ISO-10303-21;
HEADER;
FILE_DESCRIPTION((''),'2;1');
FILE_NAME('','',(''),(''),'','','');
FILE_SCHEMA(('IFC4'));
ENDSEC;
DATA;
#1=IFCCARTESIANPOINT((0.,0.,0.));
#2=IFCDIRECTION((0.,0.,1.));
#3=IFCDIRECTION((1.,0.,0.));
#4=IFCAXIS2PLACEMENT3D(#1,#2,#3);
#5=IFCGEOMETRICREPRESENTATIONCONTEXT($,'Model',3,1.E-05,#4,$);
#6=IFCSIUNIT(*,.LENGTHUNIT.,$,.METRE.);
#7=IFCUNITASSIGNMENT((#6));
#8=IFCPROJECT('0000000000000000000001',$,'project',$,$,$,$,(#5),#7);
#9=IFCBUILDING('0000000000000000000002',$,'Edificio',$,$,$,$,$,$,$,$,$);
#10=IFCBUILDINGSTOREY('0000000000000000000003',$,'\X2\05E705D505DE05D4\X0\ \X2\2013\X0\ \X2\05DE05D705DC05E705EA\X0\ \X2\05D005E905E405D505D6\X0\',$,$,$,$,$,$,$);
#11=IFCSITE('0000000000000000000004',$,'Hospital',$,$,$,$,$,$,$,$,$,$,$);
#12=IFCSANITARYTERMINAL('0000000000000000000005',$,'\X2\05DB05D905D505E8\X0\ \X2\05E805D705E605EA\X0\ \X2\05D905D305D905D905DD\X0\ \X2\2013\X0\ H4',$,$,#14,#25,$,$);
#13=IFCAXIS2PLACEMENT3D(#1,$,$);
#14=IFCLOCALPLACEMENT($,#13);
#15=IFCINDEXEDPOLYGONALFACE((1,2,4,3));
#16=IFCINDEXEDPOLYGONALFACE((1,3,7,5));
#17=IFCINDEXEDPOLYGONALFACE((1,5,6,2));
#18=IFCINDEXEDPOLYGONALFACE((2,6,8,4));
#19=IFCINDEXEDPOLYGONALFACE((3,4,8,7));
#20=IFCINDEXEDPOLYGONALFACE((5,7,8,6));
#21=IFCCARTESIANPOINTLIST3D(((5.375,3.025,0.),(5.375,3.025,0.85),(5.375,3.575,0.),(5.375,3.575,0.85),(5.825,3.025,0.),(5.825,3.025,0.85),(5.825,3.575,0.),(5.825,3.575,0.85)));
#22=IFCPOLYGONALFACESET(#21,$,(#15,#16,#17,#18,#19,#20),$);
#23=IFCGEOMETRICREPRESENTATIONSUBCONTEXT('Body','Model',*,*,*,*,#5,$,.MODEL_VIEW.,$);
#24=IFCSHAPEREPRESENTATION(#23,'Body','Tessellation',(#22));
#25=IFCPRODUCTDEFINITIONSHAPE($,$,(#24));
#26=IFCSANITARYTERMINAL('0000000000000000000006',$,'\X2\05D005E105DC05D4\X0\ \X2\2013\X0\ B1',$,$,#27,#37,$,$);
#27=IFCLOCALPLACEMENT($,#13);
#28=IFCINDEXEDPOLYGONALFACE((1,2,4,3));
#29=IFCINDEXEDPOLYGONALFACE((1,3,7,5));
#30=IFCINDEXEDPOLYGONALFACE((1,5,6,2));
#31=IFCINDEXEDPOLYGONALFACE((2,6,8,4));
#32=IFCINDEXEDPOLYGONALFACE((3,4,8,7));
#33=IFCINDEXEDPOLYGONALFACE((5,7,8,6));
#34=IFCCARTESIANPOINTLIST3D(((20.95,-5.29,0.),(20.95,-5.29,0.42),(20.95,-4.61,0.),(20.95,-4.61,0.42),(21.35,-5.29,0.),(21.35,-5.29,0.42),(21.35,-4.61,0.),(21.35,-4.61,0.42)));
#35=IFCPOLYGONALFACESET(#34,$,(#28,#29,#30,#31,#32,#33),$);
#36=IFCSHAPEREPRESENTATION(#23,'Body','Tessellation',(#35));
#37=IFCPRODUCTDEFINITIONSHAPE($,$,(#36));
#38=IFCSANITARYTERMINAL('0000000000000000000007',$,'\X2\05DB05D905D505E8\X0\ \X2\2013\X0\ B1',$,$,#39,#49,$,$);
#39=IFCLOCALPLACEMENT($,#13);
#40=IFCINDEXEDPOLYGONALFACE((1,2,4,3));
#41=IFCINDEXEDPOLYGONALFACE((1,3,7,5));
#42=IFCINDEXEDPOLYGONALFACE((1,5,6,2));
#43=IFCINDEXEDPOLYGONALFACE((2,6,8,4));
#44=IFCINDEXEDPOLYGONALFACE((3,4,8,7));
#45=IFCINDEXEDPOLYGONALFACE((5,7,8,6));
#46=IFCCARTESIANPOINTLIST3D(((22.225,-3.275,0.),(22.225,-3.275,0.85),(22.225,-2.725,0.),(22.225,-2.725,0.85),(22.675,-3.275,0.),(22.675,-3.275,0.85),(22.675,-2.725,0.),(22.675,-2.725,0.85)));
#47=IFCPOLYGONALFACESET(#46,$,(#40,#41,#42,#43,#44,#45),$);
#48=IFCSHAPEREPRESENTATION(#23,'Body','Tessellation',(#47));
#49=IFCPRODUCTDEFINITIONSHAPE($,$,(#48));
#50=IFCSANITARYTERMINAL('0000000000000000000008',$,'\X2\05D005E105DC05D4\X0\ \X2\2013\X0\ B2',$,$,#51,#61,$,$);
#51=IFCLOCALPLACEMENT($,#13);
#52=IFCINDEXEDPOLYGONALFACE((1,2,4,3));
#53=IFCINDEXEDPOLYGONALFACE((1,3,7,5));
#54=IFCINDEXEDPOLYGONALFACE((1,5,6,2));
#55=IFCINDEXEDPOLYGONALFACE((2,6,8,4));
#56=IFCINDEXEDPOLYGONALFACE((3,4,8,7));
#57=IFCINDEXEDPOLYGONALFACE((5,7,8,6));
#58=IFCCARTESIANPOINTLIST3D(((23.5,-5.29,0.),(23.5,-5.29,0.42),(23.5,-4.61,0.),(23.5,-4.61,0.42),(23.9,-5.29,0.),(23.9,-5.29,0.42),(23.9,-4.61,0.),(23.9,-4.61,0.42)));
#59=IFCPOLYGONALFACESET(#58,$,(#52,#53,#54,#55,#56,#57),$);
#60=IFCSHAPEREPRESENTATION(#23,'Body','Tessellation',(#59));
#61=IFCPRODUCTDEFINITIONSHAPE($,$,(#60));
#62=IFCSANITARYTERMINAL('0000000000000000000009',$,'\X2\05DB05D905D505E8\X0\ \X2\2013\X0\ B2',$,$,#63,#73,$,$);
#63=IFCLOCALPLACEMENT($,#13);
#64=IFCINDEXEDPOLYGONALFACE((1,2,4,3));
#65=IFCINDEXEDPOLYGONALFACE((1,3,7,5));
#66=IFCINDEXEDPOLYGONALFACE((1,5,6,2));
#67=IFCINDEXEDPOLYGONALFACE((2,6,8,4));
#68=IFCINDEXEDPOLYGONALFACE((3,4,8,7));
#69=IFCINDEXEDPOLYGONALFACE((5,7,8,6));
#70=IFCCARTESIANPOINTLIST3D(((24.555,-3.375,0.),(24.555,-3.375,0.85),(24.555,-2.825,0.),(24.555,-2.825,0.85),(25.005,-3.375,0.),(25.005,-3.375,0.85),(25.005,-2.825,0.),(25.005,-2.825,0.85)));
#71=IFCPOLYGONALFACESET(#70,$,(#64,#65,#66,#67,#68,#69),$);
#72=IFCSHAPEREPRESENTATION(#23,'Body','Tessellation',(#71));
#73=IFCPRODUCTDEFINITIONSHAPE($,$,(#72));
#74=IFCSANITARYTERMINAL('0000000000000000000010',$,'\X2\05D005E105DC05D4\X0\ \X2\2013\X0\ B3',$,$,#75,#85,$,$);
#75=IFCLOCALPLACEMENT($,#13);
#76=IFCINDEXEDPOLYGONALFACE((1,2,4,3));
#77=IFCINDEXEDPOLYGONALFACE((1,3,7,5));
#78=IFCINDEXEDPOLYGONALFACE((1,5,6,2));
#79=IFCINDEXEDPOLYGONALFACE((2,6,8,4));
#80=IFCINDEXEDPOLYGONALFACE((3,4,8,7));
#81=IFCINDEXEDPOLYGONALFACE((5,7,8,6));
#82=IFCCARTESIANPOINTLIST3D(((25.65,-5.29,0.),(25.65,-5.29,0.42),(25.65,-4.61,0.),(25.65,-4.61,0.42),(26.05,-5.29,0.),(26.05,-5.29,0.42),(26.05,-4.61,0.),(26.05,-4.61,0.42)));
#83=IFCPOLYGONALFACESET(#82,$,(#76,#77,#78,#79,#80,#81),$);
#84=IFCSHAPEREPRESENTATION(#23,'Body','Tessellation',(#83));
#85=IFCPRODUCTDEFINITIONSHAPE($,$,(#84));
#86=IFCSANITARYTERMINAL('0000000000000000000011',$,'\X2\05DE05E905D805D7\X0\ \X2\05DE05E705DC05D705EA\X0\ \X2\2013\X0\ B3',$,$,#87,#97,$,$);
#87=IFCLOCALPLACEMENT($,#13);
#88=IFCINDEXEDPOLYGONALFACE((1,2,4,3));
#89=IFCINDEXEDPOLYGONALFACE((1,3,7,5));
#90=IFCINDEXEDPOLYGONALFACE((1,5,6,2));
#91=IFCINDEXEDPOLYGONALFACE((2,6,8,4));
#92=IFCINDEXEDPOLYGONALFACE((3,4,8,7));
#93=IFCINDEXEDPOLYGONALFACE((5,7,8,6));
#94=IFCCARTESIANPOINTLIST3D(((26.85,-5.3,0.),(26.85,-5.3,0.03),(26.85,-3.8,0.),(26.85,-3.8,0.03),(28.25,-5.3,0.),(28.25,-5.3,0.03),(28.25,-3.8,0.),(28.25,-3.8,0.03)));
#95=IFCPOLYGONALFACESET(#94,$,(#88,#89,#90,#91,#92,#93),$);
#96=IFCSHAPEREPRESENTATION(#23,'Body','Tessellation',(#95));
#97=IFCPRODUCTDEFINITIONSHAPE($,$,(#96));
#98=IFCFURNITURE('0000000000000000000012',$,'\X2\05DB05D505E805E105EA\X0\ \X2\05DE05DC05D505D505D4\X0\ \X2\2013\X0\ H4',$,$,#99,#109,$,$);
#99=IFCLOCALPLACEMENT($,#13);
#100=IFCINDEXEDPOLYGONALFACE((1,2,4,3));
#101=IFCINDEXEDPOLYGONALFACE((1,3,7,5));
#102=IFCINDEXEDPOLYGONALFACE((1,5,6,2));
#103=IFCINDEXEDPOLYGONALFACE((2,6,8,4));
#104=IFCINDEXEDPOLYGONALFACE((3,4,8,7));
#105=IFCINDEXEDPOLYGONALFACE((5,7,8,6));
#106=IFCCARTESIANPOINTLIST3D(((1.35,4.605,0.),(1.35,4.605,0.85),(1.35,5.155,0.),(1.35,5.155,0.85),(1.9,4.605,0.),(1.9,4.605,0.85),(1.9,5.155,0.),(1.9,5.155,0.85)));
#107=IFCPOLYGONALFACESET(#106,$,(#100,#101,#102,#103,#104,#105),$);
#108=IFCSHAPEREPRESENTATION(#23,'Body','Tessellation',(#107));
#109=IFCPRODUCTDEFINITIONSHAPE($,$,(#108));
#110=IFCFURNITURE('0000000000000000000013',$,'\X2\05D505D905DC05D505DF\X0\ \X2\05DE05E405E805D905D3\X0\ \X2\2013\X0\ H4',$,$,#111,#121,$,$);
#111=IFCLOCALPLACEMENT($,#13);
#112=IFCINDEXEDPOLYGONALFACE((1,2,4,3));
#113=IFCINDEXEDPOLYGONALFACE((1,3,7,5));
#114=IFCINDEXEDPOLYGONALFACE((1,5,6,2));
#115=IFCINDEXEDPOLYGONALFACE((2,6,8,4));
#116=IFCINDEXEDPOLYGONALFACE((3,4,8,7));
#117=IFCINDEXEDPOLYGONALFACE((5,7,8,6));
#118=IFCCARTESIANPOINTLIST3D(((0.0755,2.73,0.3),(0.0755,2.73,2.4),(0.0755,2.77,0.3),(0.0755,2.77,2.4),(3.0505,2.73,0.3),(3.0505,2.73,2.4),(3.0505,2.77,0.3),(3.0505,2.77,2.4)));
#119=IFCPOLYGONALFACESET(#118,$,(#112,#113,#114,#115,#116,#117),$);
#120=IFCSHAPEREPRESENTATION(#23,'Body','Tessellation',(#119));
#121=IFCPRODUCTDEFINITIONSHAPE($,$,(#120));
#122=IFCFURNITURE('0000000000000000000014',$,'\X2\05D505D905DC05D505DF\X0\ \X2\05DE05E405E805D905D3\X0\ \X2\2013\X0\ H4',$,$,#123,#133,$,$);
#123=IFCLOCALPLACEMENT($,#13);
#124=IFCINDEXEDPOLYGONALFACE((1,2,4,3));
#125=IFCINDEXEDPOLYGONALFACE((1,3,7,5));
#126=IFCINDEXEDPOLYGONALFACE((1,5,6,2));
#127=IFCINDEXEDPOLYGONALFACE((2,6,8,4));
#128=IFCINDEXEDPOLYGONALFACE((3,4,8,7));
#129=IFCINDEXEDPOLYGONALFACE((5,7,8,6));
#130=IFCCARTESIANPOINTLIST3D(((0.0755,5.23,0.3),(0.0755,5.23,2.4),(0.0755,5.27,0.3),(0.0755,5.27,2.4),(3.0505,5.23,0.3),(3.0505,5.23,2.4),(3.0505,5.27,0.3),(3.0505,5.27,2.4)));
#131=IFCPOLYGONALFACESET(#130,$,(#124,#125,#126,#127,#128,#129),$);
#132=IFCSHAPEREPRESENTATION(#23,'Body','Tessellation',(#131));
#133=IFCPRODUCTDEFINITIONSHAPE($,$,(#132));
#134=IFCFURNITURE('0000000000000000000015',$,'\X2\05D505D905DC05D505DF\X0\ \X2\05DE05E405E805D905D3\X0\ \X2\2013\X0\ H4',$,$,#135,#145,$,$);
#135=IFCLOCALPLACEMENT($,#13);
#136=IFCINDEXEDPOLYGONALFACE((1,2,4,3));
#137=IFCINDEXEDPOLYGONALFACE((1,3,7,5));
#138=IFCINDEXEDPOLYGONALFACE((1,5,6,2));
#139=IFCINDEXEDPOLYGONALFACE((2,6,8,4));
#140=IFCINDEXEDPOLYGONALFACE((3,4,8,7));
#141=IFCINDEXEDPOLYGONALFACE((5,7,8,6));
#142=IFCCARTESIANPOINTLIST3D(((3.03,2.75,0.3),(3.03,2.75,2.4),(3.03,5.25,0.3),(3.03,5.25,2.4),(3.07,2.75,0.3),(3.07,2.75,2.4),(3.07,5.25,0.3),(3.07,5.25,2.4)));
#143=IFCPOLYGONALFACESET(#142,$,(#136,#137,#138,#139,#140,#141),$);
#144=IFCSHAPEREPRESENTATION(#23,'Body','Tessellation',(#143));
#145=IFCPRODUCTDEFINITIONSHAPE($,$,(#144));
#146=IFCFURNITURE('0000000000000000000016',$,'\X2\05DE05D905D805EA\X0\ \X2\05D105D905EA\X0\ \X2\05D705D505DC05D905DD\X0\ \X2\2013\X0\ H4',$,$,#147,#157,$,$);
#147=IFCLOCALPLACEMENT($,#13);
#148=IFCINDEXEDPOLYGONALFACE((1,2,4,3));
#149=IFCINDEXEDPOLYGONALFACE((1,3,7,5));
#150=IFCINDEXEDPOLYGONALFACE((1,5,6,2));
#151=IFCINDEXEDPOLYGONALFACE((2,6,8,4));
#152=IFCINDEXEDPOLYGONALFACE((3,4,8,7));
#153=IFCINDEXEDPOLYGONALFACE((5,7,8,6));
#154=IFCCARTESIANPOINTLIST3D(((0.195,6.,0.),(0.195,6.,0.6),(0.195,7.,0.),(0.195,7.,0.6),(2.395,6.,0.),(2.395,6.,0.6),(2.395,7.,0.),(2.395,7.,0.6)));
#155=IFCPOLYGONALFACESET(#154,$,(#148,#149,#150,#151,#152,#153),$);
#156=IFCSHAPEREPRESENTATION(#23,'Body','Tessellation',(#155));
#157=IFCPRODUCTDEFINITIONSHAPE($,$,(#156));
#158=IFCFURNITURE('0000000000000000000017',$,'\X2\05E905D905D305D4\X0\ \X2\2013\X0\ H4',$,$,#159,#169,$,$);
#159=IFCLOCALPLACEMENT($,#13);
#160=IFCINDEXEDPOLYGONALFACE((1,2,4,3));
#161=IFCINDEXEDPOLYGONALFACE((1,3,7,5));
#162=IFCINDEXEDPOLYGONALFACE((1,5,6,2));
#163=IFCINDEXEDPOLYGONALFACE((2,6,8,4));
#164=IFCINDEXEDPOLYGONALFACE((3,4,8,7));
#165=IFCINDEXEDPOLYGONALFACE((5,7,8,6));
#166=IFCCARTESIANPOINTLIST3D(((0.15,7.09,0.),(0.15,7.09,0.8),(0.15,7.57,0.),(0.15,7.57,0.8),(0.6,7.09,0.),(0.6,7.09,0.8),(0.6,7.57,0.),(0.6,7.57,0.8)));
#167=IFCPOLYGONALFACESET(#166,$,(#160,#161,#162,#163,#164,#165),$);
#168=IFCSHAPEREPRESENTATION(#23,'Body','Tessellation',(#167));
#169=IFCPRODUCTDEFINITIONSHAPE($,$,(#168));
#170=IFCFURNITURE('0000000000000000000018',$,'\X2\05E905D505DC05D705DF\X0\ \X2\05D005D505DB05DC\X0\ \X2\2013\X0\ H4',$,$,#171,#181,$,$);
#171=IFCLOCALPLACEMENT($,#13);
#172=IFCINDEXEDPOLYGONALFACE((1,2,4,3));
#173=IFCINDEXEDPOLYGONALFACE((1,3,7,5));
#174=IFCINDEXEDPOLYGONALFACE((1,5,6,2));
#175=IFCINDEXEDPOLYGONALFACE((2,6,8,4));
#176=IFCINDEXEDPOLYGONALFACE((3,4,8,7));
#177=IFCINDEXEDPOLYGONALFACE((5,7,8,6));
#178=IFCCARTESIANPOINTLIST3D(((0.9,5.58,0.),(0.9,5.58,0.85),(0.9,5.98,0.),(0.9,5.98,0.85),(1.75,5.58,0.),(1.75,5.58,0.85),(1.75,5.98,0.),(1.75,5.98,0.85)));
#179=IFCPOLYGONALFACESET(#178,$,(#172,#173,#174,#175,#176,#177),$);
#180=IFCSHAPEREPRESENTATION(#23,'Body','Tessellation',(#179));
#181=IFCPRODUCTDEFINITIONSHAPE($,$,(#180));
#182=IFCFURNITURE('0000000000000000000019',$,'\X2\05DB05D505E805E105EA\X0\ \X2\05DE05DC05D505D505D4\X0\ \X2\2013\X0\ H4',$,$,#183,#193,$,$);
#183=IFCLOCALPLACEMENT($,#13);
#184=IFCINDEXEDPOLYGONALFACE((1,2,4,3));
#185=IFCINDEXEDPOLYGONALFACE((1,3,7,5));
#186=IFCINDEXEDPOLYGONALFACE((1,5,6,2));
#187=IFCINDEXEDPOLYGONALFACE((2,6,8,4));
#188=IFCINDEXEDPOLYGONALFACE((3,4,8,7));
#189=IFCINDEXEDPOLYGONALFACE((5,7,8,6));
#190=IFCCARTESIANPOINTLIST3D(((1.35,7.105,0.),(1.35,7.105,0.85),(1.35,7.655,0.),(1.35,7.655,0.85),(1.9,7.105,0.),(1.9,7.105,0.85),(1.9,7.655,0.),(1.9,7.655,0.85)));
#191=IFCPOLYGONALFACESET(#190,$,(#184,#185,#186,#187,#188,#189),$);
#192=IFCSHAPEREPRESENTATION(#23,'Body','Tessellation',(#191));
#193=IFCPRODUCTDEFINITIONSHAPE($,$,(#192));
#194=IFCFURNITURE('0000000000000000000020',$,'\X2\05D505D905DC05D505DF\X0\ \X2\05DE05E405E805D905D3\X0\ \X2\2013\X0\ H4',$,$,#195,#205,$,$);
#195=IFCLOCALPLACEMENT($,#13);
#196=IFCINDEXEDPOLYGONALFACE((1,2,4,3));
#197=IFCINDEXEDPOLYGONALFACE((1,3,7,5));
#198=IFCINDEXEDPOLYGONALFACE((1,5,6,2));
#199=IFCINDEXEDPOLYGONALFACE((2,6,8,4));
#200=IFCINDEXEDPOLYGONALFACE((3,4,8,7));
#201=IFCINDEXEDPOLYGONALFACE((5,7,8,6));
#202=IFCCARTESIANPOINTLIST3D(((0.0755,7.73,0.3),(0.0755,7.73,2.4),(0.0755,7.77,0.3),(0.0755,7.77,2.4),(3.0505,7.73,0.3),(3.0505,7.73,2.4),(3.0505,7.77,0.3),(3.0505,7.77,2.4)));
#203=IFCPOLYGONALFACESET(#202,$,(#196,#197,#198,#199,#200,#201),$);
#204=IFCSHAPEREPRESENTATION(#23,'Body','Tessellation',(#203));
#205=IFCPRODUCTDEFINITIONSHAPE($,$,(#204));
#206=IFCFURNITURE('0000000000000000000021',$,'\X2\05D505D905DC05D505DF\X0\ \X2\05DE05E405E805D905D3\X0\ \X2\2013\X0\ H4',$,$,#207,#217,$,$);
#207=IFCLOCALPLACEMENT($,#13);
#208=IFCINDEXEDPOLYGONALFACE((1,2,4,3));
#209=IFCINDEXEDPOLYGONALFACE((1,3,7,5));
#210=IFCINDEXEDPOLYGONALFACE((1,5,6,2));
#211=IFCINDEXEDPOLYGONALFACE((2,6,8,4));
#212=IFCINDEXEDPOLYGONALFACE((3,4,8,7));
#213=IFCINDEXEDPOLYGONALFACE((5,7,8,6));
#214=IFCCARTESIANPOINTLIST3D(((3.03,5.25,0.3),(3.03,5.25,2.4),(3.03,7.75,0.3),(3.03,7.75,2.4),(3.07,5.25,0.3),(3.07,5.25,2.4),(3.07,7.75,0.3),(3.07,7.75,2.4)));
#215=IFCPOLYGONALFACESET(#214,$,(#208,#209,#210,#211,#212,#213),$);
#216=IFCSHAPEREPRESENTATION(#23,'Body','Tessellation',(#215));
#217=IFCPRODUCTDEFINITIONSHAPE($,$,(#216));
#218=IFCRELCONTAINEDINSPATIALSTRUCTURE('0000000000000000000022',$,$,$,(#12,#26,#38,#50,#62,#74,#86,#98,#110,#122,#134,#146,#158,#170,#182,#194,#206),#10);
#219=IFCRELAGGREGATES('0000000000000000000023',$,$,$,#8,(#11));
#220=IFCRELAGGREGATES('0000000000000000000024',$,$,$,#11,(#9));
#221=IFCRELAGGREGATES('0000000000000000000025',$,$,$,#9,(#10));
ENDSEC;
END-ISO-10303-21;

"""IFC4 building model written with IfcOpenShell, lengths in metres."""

from ifc_helpers import new_model, si_unit, frame, origin_with_axes, context, subcontext, project, spatial, line, indexed_curve, outline, extrude, element, save


model = new_model("IFC4")

# Units and contexts
model_context = context("Model", 3, precision=1e-05, world=origin_with_axes())
body_context = subcontext(model_context, "Body", "Model", "MODEL_VIEW")
ifc_project = project(units=[si_unit("LENGTHUNIT", "METRE")], contexts=[model_context])

# Site, building, storey
site = spatial("IfcSite", under=ifc_project, Name="Hospital")
building = spatial("IfcBuilding", under=site, Name="Edificio")
storey = spatial("IfcBuildingStorey", under=building, Name="קומה – מחלקת אשפוז")

# Sanitary terminals
element("IfcSanitaryTerminal", 1, inside=storey, Name="כיור רחצת ידיים – H4", context=body_context, shape_type="SweptSolid", body=[
    extrude(outline(indexed_curve([(0.0, 0.0), (0.45, 0.0), (0.45, 0.55), (0.0, 0.55)], segments=[line(1, 2, 3, 4, 1)])), frame((5.375, 3.025, 0.0), z_axis=(0.0, 0.0, 1.0), x_axis=(1.0, 0.0, 0.0)), (0.0, 0.0, 1.0), 0.85),
])
element("IfcSanitaryTerminal", 2, inside=storey, Name="אסלה – B1", context=body_context, shape_type="SweptSolid", body=[
    extrude(outline(indexed_curve([(0.0, 0.0), (0.4, 0.0), (0.4, 0.68), (0.0, 0.68)], segments=[line(1, 2, 3, 4, 1)])), frame((20.95, -5.29, 0.0), z_axis=(0.0, 0.0, 1.0), x_axis=(1.0, 0.0, 0.0)), (0.0, 0.0, 1.0), 0.42),
])
element("IfcSanitaryTerminal", 3, inside=storey, Name="כיור – B1", context=body_context, shape_type="SweptSolid", body=[
    extrude(outline(indexed_curve([(0.0, 0.0), (0.45, 0.0), (0.45, 0.55), (0.0, 0.55)], segments=[line(1, 2, 3, 4, 1)])), frame((22.225, -3.275, 0.0), z_axis=(0.0, 0.0, 1.0), x_axis=(1.0, 0.0, 0.0)), (0.0, 0.0, 1.0), 0.85),
])
element("IfcSanitaryTerminal", 4, inside=storey, Name="אסלה – B2", context=body_context, shape_type="SweptSolid", body=[
    extrude(outline(indexed_curve([(0.0, 0.0), (0.4, 0.0), (0.4, 0.68), (0.0, 0.68)], segments=[line(1, 2, 3, 4, 1)])), frame((23.5, -5.29, 0.0), z_axis=(0.0, 0.0, 1.0), x_axis=(1.0, 0.0, 0.0)), (0.0, 0.0, 1.0), 0.42),
])
element("IfcSanitaryTerminal", 5, inside=storey, Name="כיור – B2", context=body_context, shape_type="SweptSolid", body=[
    extrude(outline(indexed_curve([(0.0, 0.0), (0.45, 0.0), (0.45, 0.55), (0.0, 0.55)], segments=[line(1, 2, 3, 4, 1)])), frame((24.555, -3.375, 0.0), z_axis=(0.0, 0.0, 1.0), x_axis=(1.0, 0.0, 0.0)), (0.0, 0.0, 1.0), 0.85),
])
element("IfcSanitaryTerminal", 6, inside=storey, Name="אסלה – B3", context=body_context, shape_type="SweptSolid", body=[
    extrude(outline(indexed_curve([(0.0, 0.0), (0.4, 0.0), (0.4, 0.68), (0.0, 0.68)], segments=[line(1, 2, 3, 4, 1)])), frame((25.65, -5.29, 0.0), z_axis=(0.0, 0.0, 1.0), x_axis=(1.0, 0.0, 0.0)), (0.0, 0.0, 1.0), 0.42),
])
element("IfcSanitaryTerminal", 7, inside=storey, Name="משטח מקלחת – B3", context=body_context, shape_type="SweptSolid", body=[
    extrude(outline(indexed_curve([(0.0, 0.0), (1.4, 0.0), (1.4, 1.5), (0.0, 1.5)], segments=[line(1, 2, 3, 4, 1)])), frame((26.85, -5.3, 0.0), z_axis=(0.0, 0.0, 1.0), x_axis=(1.0, 0.0, 0.0)), (0.0, 0.0, 1.0), 0.03),
])

# Furniture
element("IfcFurniture", 8, inside=storey, Name="כורסת מלווה – H4", context=body_context, shape_type="SweptSolid", body=[
    extrude(outline(indexed_curve([(0.0, 0.0), (0.55, 0.0), (0.55, 0.55), (0.0, 0.55)], segments=[line(1, 2, 3, 4, 1)])), frame((1.35, 4.605, 0.0), z_axis=(0.0, 0.0, 1.0), x_axis=(1.0, 0.0, 0.0)), (0.0, 0.0, 1.0), 0.85),
])
element("IfcFurniture", 9, inside=storey, Name="וילון מפריד – H4", context=body_context, shape_type="SweptSolid", body=[
    extrude(outline(indexed_curve([(0.0, 0.0), (2.975, 0.0), (2.975, 0.04), (0.0, 0.04)], segments=[line(1, 2, 3, 4, 1)])), frame((0.0755, 2.73, 0.3), z_axis=(0.0, 0.0, 1.0), x_axis=(1.0, 0.0, 0.0)), (0.0, 0.0, 1.0), 2.1),
])
element("IfcFurniture", 10, inside=storey, Name="וילון מפריד – H4", context=body_context, shape_type="SweptSolid", body=[
    extrude(outline(indexed_curve([(0.0, 0.0), (2.975, 0.0), (2.975, 0.04), (0.0, 0.04)], segments=[line(1, 2, 3, 4, 1)])), frame((0.0755, 5.23, 0.3), z_axis=(0.0, 0.0, 1.0), x_axis=(1.0, 0.0, 0.0)), (0.0, 0.0, 1.0), 2.1),
])
element("IfcFurniture", 11, inside=storey, Name="וילון מפריד – H4", context=body_context, shape_type="SweptSolid", body=[
    extrude(outline(indexed_curve([(0.0, 0.0), (0.04, 0.0), (0.04, 2.5), (0.0, 2.5)], segments=[line(1, 2, 3, 4, 1)])), frame((3.03, 2.75, 0.3), z_axis=(0.0, 0.0, 1.0), x_axis=(1.0, 0.0, 0.0)), (0.0, 0.0, 1.0), 2.1),
])
element("IfcFurniture", 12, inside=storey, Name="מיטת בית חולים – H4", context=body_context, shape_type="SweptSolid", body=[
    extrude(outline(indexed_curve([(0.0, 0.0), (2.2, 0.0), (2.2, 1.0), (0.0, 1.0)], segments=[line(1, 2, 3, 4, 1)])), frame((0.195, 6.0, 0.0), z_axis=(0.0, 0.0, 1.0), x_axis=(1.0, 0.0, 0.0)), (0.0, 0.0, 1.0), 0.6),
])
element("IfcFurniture", 13, inside=storey, Name="שידה – H4", context=body_context, shape_type="SweptSolid", body=[
    extrude(outline(indexed_curve([(0.0, 0.0), (0.45, 0.0), (0.45, 0.48), (0.0, 0.48)], segments=[line(1, 2, 3, 4, 1)])), frame((0.15, 7.09, 0.0), z_axis=(0.0, 0.0, 1.0), x_axis=(1.0, 0.0, 0.0)), (0.0, 0.0, 1.0), 0.8),
])
element("IfcFurniture", 14, inside=storey, Name="שולחן אוכל – H4", context=body_context, shape_type="SweptSolid", body=[
    extrude(outline(indexed_curve([(0.0, 0.0), (0.85, 0.0), (0.85, 0.4), (0.0, 0.4)], segments=[line(1, 2, 3, 4, 1)])), frame((0.9, 5.58, 0.0), z_axis=(0.0, 0.0, 1.0), x_axis=(1.0, 0.0, 0.0)), (0.0, 0.0, 1.0), 0.85),
])
element("IfcFurniture", 15, inside=storey, Name="כורסת מלווה – H4", context=body_context, shape_type="SweptSolid", body=[
    extrude(outline(indexed_curve([(0.0, 0.0), (0.55, 0.0), (0.55, 0.55), (0.0, 0.55)], segments=[line(1, 2, 3, 4, 1)])), frame((1.35, 7.105, 0.0), z_axis=(0.0, 0.0, 1.0), x_axis=(1.0, 0.0, 0.0)), (0.0, 0.0, 1.0), 0.85),
])
element("IfcFurniture", 16, inside=storey, Name="וילון מפריד – H4", context=body_context, shape_type="SweptSolid", body=[
    extrude(outline(indexed_curve([(0.0, 0.0), (2.975, 0.0), (2.975, 0.04), (0.0, 0.04)], segments=[line(1, 2, 3, 4, 1)])), frame((0.0755, 7.73, 0.3), z_axis=(0.0, 0.0, 1.0), x_axis=(1.0, 0.0, 0.0)), (0.0, 0.0, 1.0), 2.1),
])
element("IfcFurniture", 17, inside=storey, Name="וילון מפריד – H4", context=body_context, shape_type="SweptSolid", body=[
    extrude(outline(indexed_curve([(0.0, 0.0), (0.04, 0.0), (0.04, 2.5), (0.0, 2.5)], segments=[line(1, 2, 3, 4, 1)])), frame((3.03, 5.25, 0.3), z_axis=(0.0, 0.0, 1.0), x_axis=(1.0, 0.0, 0.0)), (0.0, 0.0, 1.0), 2.1),
])

save(model, "model.ifc")
